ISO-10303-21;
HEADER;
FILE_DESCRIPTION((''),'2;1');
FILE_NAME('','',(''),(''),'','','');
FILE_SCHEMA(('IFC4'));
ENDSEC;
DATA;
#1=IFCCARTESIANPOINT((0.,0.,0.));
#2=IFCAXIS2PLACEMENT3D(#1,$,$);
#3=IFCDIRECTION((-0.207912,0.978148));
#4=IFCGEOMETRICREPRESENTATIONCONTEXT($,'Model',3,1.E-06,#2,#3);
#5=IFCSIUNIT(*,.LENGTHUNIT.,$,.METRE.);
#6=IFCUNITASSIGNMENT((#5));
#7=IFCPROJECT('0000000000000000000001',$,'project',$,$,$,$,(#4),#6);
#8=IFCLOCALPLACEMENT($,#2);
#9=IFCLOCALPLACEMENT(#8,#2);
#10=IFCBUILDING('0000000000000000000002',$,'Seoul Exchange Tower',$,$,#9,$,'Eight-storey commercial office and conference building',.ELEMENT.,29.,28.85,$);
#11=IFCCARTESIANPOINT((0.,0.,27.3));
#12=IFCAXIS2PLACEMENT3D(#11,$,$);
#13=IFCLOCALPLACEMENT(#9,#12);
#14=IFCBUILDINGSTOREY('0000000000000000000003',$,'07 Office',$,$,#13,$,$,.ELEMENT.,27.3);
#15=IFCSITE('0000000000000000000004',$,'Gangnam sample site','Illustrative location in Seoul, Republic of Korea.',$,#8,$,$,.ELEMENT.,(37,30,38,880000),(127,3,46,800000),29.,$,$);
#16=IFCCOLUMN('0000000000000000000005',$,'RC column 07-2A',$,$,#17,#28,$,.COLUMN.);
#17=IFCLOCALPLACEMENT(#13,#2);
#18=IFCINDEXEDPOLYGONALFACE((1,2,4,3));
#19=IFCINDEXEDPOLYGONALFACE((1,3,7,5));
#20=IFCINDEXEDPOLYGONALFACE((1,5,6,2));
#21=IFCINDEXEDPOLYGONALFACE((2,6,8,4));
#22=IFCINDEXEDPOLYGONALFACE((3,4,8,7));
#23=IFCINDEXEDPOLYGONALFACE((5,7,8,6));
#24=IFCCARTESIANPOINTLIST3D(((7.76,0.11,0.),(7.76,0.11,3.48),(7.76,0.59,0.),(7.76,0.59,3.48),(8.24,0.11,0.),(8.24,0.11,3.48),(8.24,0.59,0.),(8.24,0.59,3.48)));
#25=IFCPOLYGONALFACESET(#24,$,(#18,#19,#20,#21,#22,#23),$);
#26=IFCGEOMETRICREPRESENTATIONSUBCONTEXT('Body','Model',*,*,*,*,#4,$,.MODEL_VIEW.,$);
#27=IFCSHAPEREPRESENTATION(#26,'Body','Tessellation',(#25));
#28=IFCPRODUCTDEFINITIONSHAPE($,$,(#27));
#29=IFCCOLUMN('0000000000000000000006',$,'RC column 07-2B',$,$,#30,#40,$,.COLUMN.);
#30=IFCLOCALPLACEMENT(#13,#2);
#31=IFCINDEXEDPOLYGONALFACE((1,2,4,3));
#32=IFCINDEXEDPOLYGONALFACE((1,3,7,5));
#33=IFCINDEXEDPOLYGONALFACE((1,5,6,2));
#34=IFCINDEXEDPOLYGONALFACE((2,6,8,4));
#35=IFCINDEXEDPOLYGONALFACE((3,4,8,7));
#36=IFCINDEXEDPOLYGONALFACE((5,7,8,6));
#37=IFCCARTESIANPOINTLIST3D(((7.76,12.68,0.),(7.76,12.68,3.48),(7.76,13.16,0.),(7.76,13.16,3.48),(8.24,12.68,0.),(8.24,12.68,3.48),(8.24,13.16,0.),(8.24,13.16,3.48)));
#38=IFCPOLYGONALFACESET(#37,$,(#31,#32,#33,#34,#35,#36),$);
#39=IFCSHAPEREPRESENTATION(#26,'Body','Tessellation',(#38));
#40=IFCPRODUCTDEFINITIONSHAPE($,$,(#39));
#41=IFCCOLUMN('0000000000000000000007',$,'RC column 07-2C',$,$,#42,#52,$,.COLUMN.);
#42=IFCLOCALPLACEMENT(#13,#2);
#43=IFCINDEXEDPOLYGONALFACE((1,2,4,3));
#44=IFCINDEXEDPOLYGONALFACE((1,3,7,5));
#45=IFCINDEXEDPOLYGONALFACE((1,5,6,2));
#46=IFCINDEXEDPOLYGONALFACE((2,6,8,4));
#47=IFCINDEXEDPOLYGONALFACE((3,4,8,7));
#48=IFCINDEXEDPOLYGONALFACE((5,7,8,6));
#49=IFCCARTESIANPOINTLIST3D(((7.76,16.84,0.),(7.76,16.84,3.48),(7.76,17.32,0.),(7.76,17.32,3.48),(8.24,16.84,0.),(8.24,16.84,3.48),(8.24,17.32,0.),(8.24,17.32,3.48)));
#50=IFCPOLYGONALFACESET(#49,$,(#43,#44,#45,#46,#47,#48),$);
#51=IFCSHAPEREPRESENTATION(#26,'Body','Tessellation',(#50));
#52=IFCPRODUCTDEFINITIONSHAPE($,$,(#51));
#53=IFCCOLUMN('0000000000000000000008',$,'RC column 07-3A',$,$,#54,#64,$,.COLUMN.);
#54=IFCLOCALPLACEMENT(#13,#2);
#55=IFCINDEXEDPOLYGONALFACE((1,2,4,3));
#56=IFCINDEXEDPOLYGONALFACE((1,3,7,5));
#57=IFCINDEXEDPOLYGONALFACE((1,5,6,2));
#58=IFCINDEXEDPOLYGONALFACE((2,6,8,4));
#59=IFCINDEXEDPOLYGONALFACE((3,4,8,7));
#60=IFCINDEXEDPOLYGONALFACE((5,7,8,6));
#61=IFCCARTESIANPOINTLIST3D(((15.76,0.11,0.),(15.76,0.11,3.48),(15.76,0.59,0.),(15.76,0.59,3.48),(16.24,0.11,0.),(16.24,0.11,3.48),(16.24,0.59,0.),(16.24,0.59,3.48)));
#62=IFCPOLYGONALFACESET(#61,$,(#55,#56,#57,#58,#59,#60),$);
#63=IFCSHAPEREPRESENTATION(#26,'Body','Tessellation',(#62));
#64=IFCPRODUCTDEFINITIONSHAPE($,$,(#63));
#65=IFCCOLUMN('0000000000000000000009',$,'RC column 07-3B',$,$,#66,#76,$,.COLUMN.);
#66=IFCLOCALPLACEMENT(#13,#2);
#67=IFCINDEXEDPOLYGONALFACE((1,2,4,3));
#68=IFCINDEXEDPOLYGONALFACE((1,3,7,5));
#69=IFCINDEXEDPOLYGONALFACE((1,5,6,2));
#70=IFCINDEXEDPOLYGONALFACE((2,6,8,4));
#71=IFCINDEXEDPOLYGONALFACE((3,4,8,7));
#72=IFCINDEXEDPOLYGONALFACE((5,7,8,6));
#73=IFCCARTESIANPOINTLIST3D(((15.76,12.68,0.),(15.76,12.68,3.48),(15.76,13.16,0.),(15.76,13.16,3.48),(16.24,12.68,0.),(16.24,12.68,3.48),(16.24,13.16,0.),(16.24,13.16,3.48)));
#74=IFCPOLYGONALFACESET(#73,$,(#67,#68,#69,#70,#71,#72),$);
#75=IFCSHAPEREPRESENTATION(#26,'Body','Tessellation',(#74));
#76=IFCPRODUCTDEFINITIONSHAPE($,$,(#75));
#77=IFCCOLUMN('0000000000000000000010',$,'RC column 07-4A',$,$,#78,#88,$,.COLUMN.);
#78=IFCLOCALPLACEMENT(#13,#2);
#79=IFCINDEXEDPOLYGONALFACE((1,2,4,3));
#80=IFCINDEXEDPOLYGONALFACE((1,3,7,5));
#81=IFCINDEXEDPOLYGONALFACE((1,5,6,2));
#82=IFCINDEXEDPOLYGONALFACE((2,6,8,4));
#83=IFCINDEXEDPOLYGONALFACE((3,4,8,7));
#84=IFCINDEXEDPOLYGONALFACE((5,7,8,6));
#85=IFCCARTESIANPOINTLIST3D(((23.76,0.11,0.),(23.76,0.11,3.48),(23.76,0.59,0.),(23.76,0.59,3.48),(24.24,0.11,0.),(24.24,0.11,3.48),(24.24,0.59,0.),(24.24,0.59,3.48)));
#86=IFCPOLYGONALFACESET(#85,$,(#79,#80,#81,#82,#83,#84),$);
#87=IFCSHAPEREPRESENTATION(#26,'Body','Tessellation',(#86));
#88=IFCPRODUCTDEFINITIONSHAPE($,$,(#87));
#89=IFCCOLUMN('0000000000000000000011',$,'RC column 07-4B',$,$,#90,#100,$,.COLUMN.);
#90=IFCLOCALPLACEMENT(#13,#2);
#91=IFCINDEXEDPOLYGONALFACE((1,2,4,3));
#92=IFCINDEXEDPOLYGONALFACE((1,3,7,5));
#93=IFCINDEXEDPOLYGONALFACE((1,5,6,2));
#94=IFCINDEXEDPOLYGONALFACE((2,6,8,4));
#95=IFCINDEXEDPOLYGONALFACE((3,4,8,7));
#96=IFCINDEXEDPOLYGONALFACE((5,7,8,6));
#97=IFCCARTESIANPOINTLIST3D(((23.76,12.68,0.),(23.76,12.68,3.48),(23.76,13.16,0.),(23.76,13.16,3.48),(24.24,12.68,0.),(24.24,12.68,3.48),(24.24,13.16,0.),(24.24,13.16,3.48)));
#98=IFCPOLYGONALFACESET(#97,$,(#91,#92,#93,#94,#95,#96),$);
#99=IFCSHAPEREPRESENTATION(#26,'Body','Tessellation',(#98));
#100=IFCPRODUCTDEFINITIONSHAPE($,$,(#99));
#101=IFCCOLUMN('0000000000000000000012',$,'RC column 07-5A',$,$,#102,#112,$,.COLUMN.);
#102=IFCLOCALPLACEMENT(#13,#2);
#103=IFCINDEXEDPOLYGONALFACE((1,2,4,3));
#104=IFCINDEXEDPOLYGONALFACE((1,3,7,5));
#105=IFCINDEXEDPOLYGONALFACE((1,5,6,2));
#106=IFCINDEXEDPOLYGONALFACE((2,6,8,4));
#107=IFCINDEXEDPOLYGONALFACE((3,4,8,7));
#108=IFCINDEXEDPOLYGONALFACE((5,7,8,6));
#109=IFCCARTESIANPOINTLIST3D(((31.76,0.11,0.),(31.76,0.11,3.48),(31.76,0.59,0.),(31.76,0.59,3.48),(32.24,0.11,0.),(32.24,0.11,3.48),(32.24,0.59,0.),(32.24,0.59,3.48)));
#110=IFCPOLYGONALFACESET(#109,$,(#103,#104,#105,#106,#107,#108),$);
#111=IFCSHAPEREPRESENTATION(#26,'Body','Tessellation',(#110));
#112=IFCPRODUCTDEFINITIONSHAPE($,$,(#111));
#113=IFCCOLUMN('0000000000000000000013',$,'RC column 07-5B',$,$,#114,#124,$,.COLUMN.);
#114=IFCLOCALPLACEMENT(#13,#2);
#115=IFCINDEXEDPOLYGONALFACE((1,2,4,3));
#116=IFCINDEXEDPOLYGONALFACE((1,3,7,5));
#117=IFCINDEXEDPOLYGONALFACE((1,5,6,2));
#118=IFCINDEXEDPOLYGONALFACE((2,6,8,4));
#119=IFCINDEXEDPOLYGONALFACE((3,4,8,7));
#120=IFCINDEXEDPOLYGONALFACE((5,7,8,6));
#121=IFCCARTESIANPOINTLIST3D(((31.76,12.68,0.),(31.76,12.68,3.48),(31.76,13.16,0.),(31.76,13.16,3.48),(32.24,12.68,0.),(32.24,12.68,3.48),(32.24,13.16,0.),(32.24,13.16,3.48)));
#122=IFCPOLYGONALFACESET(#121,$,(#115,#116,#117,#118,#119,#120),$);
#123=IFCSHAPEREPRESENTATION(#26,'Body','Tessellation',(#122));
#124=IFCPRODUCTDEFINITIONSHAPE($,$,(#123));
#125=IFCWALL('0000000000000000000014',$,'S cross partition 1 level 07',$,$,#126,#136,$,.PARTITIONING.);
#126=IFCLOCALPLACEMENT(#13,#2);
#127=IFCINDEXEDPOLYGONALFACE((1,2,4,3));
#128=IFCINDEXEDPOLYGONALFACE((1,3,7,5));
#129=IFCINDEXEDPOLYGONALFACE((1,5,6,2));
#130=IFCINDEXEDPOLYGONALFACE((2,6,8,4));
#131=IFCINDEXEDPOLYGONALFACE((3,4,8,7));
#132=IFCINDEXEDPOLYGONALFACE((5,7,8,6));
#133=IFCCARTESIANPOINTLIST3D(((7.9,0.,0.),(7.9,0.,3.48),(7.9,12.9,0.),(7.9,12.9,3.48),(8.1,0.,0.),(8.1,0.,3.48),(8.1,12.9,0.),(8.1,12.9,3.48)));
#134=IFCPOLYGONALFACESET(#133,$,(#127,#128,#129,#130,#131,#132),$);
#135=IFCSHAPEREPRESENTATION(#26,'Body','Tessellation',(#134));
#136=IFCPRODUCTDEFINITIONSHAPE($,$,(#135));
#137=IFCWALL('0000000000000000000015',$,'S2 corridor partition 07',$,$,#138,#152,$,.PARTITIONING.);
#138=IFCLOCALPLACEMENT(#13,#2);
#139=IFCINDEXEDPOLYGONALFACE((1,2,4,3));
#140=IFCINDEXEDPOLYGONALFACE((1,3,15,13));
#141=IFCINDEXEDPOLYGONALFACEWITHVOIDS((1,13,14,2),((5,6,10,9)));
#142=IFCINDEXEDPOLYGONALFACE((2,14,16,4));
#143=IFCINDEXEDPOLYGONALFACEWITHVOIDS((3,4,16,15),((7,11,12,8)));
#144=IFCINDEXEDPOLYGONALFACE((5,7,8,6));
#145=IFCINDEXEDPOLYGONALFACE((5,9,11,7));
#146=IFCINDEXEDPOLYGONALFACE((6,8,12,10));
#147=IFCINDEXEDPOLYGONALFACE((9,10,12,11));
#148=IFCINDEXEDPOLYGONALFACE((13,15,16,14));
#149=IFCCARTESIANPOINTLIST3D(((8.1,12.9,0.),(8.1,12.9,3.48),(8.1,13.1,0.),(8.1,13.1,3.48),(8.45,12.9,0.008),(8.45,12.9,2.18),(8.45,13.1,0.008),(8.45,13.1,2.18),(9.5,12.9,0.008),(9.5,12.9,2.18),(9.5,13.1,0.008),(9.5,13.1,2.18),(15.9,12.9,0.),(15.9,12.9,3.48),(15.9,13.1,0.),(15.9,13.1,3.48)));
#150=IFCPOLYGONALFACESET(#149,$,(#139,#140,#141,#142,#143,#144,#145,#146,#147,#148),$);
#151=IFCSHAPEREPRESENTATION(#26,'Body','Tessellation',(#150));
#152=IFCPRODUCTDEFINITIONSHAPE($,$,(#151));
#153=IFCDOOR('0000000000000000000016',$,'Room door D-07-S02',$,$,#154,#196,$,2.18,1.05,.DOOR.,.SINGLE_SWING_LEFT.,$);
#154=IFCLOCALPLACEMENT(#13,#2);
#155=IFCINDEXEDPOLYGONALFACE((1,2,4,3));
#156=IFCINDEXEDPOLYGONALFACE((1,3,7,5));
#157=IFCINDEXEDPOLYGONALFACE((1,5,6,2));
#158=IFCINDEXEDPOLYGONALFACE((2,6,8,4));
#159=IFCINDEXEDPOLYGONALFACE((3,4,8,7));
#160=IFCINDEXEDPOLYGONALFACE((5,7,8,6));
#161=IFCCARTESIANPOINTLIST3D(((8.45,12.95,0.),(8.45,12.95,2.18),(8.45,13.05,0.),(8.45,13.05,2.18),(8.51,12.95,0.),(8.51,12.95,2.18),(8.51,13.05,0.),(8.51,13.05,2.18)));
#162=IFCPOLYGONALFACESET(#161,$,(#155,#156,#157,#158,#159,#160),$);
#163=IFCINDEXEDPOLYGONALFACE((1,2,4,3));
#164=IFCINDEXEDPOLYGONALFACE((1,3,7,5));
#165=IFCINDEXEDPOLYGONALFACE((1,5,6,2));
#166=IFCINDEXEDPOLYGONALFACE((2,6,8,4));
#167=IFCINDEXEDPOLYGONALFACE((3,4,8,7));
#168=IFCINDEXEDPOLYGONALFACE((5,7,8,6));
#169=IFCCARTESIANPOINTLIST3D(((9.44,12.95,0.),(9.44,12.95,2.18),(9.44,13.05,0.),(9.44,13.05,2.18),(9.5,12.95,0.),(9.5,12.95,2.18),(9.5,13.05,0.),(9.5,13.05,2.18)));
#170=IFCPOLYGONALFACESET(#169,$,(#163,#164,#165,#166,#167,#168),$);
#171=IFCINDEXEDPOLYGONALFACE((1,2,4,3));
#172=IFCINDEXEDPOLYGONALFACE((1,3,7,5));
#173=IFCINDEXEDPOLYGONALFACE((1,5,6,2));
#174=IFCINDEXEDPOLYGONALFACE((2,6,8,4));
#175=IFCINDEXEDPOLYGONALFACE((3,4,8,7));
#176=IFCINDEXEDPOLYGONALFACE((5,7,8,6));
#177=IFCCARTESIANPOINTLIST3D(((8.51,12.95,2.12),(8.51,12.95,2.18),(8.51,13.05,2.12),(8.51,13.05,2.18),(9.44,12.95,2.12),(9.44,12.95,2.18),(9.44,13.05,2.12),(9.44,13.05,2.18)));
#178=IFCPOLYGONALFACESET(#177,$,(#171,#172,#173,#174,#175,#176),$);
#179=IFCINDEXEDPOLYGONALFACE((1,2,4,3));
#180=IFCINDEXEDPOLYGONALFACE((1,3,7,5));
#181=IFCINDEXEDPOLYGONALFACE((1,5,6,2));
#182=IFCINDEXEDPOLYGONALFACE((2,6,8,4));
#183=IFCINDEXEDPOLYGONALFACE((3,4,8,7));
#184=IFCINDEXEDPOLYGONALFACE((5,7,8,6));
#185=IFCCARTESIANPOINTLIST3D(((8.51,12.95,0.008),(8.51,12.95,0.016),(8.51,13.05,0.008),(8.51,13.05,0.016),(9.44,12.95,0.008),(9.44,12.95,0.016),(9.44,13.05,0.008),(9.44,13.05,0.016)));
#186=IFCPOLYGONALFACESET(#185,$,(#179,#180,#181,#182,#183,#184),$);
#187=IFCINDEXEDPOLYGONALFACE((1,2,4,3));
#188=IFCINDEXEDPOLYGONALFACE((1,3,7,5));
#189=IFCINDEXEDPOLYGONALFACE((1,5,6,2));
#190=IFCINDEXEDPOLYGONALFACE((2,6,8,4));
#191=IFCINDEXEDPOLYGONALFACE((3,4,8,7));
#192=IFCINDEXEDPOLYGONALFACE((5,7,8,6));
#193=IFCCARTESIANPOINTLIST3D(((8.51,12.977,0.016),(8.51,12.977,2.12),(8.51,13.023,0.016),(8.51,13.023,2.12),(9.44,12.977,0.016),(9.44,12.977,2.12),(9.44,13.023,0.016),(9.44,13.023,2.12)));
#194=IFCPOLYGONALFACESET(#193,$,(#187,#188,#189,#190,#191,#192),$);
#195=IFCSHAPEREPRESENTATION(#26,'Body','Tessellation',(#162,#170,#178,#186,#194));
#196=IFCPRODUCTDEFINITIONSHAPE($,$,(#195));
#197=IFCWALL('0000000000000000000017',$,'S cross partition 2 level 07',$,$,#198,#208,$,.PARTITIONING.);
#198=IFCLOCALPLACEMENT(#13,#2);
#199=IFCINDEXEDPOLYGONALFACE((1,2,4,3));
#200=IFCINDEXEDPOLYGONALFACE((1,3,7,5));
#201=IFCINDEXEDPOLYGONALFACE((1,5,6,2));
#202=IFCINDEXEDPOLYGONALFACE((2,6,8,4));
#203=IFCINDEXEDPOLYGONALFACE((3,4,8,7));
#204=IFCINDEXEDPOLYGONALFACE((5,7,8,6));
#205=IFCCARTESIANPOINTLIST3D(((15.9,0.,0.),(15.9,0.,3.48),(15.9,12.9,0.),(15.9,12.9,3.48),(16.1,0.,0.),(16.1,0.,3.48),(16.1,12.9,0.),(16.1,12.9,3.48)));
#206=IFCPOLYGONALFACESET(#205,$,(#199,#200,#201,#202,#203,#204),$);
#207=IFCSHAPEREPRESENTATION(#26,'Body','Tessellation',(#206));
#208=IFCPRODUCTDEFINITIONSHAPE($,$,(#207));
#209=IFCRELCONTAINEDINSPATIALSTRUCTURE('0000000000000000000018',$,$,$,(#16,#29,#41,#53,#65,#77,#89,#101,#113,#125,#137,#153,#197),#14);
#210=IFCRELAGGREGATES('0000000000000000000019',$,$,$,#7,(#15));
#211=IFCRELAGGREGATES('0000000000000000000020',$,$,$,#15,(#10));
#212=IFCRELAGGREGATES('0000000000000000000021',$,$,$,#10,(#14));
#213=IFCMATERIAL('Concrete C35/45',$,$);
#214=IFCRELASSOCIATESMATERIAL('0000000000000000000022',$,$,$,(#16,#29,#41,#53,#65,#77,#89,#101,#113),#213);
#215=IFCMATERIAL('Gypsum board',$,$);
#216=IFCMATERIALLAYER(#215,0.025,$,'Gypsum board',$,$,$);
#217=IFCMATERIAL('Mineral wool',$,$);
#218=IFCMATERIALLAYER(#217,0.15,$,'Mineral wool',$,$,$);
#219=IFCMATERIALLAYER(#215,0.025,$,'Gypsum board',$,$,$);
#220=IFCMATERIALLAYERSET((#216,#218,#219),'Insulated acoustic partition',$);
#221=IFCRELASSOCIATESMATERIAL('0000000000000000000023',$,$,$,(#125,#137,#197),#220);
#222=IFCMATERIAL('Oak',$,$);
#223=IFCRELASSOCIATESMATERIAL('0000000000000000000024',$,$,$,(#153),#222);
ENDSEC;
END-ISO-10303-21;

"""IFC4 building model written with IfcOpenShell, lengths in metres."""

from ifc_helpers import new_model, si_unit, direction, frame, frame_2d, origin, place, context, subcontext, project, spatial, rectangle, extrude, material, layer, layer_set, layer_usage, element, fill, save


model = new_model("IFC4")

# Units and contexts
model_context = context("Model", 3, precision=1e-06, world=origin(), true_north=direction((-0.207912, 0.978148)))
body_context = subcontext(model_context, "Body", "Model", "MODEL_VIEW")
ifc_project = project(units=[si_unit("LENGTHUNIT", "METRE")], contexts=[model_context])

# Site, building, storey
site_placement = place(None, origin())
site = spatial("IfcSite", under=ifc_project, at=site_placement, Name="Gangnam sample site", Description="Illustrative location in Seoul, Republic of Korea.", CompositionType="ELEMENT", RefLatitude=(37, 30, 38, 880000), RefLongitude=(127, 3, 46, 800000), RefElevation=29.0)
building_placement = place(site_placement, origin())
building = spatial("IfcBuilding", under=site, at=building_placement, Name="Seoul Exchange Tower", LongName="Eight-storey commercial office and conference building", CompositionType="ELEMENT", ElevationOfRefHeight=29.0, ElevationOfTerrain=28.85)
storey_placement = place(building_placement, frame((0.0, 0.0, 27.3)))
storey = spatial("IfcBuildingStorey", under=building, at=storey_placement, Name="07 Office", CompositionType="ELEMENT", Elevation=27.3)

# Columns
ifc_material_1 = material(Name="Concrete C35/45")
for number, where, name in (
    (1, (7.76, 0.11, 0.0), "RC column 07-2A"),
    (2, (7.76, 12.68, 0.0), "RC column 07-2B"),
    (3, (7.76, 16.84, 0.0), "RC column 07-2C"),
    (4, (15.76, 0.11, 0.0), "RC column 07-3A"),
    (5, (15.76, 12.68, 0.0), "RC column 07-3B"),
    (6, (23.76, 0.11, 0.0), "RC column 07-4A"),
    (7, (23.76, 12.68, 0.0), "RC column 07-4B"),
    (8, (31.76, 0.11, 0.0), "RC column 07-5A"),
    (9, (31.76, 12.68, 0.0), "RC column 07-5B"),
):
    element("IfcColumn", number, at=place(storey_placement, frame(where)), inside=storey, material=ifc_material_1, Name=name, PredefinedType="COLUMN", context=body_context, shape_type="SweptSolid", body=[
        extrude(rectangle(XDim=0.48, YDim=0.48, at=frame_2d((0.24, 0.24))), origin(), (0.0, 0.0, 1.0), 3.48),
    ])

# Wall
ifc_material_2 = material(Name="Gypsum board")
ifc_layer_1 = layer(ifc_material_2, 0.025, Name="Gypsum board")
ifc_material_3 = material(Name="Mineral wool")
ifc_layer_2 = layer(ifc_material_3, 0.15, Name="Mineral wool")
ifc_layer_3 = layer(ifc_material_2, 0.025, Name="Gypsum board")
ifc_layer_set = layer_set([ifc_layer_1, ifc_layer_2, ifc_layer_3], Name="Insulated acoustic partition")
ifc_layer_usage = layer_usage(ifc_layer_set, "AXIS2", "POSITIVE", 0.0)
wall_1_placement = place(storey_placement, frame((8.1, 0.0, 0.0), z_axis=(0.0, 0.0, 1.0), x_axis=(0.0, 1.0, 0.0)))
element("IfcWall", 10, at=wall_1_placement, inside=storey, material=ifc_layer_usage, Name="S cross partition 1 level 07", PredefinedType="PARTITIONING", context=body_context, shape_type="SweptSolid", body=[
    extrude(rectangle(XDim=12.9, YDim=0.2, at=frame_2d((6.45, 0.1))), origin(), (0.0, 0.0, 1.0), 3.48),
])

# Wall, opening, door
wall_2_placement = place(storey_placement, frame((8.1, 12.9, 0.0)))
wall_2 = element("IfcWall", 11, at=wall_2_placement, inside=storey, material=ifc_layer_usage, Name="S2 corridor partition 07", PredefinedType="PARTITIONING", context=body_context, shape_type="SweptSolid", body=[
    extrude(rectangle(XDim=7.8, YDim=0.2, at=frame_2d((3.9, 0.1))), origin(), (0.0, 0.0, 1.0), 3.48),
])
placement_1 = place(wall_2_placement, origin())
opening_1 = element("IfcOpeningElement", 12, at=placement_1, cuts=wall_2, PredefinedType="OPENING", context=body_context, shape_type="SweptSolid", body=[
    extrude(rectangle(XDim=1.05, YDim=0.24, at=frame_2d((0.525, 0.12))), frame((0.35, -0.02, 0.008)), (0.0, 0.0, 1.0), 2.172),
])
ifc_material_4 = material(Name="Oak")
door_1 = element("IfcDoor", 13, at=placement_1, inside=storey, material=ifc_material_4, Name="Room door D-07-S02", OperationType="SINGLE_SWING_LEFT", OverallHeight=2.18, OverallWidth=1.05, PredefinedType="DOOR", context=body_context, shape_type="SweptSolid", body=[
    extrude(rectangle(XDim=0.06, YDim=0.1, at=frame_2d((0.03, 0.05))), frame((0.35, 0.05, 0.0)), (0.0, 0.0, 1.0), 2.18),
    extrude(rectangle(XDim=0.06, YDim=0.1, at=frame_2d((0.03, 0.05))), frame((1.34, 0.05, 0.0)), (0.0, 0.0, 1.0), 2.18),
    extrude(rectangle(XDim=0.93, YDim=0.1, at=frame_2d((0.465, 0.05))), frame((0.41, 0.05, 2.12)), (0.0, 0.0, 1.0), 0.06),
    extrude(rectangle(XDim=0.93, YDim=0.1, at=frame_2d((0.465, 0.05))), frame((0.41, 0.05, 0.008)), (0.0, 0.0, 1.0), 0.008),
    extrude(rectangle(XDim=0.93, YDim=0.046, at=frame_2d((0.465, 0.023))), frame((0.41, 0.077, 0.016)), (0.0, 0.0, 1.0), 2.104),
])
fill(opening_1, door_1)

# Wall
wall_3_placement = place(storey_placement, frame((16.1, 0.0, 0.0), z_axis=(0.0, 0.0, 1.0), x_axis=(0.0, 1.0, 0.0)))
element("IfcWall", 14, at=wall_3_placement, inside=storey, material=ifc_layer_usage, Name="S cross partition 2 level 07", PredefinedType="PARTITIONING", context=body_context, shape_type="SweptSolid", body=[
    extrude(rectangle(XDim=12.9, YDim=0.2, at=frame_2d((6.45, 0.1))), origin(), (0.0, 0.0, 1.0), 3.48),
])

save(model, "model.ifc")
